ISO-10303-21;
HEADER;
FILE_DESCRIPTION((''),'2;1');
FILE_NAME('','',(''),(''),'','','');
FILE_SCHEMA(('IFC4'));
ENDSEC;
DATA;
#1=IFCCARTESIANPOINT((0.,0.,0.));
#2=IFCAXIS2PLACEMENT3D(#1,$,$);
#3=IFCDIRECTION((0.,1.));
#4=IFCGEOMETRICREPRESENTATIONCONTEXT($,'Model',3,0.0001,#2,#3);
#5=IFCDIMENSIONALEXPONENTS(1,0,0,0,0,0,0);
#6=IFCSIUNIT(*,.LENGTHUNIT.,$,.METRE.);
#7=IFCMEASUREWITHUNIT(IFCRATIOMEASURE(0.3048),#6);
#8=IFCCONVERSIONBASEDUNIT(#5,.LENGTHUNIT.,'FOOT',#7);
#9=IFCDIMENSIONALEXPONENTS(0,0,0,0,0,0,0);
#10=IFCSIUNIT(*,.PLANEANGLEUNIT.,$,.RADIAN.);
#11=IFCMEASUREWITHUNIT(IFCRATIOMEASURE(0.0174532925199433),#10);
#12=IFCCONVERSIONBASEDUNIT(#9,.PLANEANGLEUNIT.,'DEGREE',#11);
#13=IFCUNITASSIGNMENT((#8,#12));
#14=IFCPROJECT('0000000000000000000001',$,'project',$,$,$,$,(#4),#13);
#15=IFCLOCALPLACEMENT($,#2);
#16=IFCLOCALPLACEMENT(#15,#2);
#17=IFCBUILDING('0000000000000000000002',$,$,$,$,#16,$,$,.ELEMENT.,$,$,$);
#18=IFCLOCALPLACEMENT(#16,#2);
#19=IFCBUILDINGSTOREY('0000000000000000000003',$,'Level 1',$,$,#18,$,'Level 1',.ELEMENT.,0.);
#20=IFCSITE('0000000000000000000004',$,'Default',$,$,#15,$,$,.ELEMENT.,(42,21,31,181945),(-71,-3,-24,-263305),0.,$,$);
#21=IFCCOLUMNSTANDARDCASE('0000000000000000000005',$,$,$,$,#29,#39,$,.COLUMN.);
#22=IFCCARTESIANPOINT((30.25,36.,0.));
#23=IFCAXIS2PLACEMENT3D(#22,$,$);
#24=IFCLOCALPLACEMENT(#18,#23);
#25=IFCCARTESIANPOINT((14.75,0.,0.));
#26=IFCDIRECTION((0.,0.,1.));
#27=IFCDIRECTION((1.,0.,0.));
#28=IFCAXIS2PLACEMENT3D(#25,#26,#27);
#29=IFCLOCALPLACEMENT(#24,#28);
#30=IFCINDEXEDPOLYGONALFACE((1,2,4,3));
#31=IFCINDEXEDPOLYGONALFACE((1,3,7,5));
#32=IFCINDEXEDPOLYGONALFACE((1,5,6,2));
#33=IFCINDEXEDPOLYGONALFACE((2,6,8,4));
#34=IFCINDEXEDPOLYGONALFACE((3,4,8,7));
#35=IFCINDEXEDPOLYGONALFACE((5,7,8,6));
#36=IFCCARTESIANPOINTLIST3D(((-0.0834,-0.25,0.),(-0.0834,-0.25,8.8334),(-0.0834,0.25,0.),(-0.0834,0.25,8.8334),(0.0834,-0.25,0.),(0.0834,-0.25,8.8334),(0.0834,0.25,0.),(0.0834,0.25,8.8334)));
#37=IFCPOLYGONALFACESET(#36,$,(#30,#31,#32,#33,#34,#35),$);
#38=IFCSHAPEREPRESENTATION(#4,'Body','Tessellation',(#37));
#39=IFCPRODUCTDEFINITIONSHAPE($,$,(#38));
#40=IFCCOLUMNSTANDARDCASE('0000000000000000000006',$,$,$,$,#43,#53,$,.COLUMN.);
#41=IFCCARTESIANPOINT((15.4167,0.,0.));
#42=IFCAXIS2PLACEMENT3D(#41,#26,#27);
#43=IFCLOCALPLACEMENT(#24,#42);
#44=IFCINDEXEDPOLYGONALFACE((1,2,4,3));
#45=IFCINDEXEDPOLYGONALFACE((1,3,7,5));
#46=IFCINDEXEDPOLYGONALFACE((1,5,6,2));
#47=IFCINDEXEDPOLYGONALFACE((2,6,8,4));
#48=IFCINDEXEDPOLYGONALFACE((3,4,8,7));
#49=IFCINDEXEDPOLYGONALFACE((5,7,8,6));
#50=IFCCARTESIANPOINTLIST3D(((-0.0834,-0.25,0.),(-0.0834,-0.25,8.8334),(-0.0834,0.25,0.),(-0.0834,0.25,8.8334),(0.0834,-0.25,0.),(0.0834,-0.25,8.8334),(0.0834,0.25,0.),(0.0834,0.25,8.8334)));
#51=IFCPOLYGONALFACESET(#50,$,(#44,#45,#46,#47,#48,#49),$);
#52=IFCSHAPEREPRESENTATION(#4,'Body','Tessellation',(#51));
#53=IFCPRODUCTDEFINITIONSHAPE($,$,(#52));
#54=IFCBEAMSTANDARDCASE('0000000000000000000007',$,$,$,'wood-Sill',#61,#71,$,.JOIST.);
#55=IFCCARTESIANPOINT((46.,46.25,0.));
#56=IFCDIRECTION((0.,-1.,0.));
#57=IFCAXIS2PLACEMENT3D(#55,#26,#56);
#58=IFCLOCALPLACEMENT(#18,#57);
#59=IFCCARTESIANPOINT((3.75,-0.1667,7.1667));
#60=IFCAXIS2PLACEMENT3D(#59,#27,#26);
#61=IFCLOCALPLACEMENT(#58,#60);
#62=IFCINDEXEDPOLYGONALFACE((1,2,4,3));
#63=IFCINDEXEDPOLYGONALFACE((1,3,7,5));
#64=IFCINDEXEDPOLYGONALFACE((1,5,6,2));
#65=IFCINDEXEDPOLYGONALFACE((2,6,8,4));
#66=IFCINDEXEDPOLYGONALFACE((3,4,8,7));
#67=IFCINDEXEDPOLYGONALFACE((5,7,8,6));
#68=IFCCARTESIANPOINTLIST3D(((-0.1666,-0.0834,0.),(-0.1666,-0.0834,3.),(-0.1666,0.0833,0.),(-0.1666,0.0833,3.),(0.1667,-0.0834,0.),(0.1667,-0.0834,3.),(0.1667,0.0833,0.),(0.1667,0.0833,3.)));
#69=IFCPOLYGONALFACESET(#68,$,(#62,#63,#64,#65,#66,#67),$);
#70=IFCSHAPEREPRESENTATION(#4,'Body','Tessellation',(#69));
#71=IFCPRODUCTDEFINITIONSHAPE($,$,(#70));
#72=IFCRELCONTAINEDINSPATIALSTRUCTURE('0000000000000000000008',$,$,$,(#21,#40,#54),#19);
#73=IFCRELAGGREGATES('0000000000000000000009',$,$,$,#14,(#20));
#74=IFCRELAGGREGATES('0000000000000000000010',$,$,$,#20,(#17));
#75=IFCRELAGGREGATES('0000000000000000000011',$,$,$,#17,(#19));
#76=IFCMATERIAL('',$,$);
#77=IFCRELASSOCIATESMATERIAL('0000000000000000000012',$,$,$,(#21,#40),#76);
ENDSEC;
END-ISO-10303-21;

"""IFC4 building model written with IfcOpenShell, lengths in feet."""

from ifc_helpers import new_model, entity, si_unit, converted_unit, direction, frame, origin, origin_with_axes, place, context, project, spatial, rectangle, extrude, material, element, save


model = new_model("IFC4")

# Units and contexts
model_context = context("Model", 3, precision=0.0001, world=origin(), true_north=direction((0.0, 1.0)))
ifc_project = project(units=[converted_unit("LENGTHUNIT", "FOOT", entity("IfcRatioMeasure", 0.3048), si_unit("LENGTHUNIT", "METRE"), dimensions=[1, 0, 0, 0, 0, 0, 0]), converted_unit("PLANEANGLEUNIT", "DEGREE", entity("IfcRatioMeasure", 0.0174532925199433), si_unit("PLANEANGLEUNIT", "RADIAN"), dimensions=[0, 0, 0, 0, 0, 0, 0])], contexts=[model_context])

# Site, building, storey
site_placement = place(None, origin())
site = spatial("IfcSite", under=ifc_project, at=site_placement, Name="Default", CompositionType="ELEMENT", RefLatitude=(42, 21, 31, 181945), RefLongitude=(-71, -3, -24, -263305), RefElevation=0.0)
building_placement = place(site_placement, origin())
building = spatial("IfcBuilding", under=site, at=building_placement, CompositionType="ELEMENT")
storey_placement = place(building_placement, origin())
storey = spatial("IfcBuildingStorey", under=building, at=storey_placement, Name="Level 1", LongName="Level 1", CompositionType="ELEMENT", Elevation=0.0)

# Columns
ifc_material_1 = material(Name="")
placement_1 = place(storey_placement, frame((46.0, 46.25, 0.0), z_axis=(0.0, 0.0, 1.0), x_axis=(0.0, -1.0, 0.0)))
placement_2 = place(storey_placement, frame((30.25, 36.0, 0.0)))
for number, where, z_axis, x_axis in (
    (1, (14.75, 0.0, 0.0), (0.0, 0.0, 1.0), (1.0, 0.0, 0.0)),
    (2, (15.4167, 0.0, 0.0), (0.0, 0.0, 1.0), (1.0, 0.0, 0.0)),
):
    element("IfcColumnStandardCase", number, at=place(placement_2, frame(where, z_axis=z_axis, x_axis=x_axis)), inside=storey, material=ifc_material_1, PredefinedType="COLUMN", context=model_context, shape_type="SweptSolid", body=[
        extrude(rectangle(XDim=0.1667, YDim=0.5), origin(), (0.0, 0.0, 1.0), 8.8334),
    ])

# Beam
for number, where, z_axis, x_axis in (
    (3, (3.75, -0.1667, 7.1667), (1.0, 0.0, 0.0), (0.0, 0.0, 1.0)),
):
    element("IfcBeamStandardCase", number, at=place(placement_1, frame(where, z_axis=z_axis, x_axis=x_axis)), inside=storey, ObjectType="wood-Sill", PredefinedType="JOIST", context=model_context, shape_type="SweptSolid", body=[
        extrude(rectangle(XDim=0.3333, YDim=0.1667), origin_with_axes(), (0.0, 0.0, 1.0), 3.0),
    ])

save(model, "model.ifc")
